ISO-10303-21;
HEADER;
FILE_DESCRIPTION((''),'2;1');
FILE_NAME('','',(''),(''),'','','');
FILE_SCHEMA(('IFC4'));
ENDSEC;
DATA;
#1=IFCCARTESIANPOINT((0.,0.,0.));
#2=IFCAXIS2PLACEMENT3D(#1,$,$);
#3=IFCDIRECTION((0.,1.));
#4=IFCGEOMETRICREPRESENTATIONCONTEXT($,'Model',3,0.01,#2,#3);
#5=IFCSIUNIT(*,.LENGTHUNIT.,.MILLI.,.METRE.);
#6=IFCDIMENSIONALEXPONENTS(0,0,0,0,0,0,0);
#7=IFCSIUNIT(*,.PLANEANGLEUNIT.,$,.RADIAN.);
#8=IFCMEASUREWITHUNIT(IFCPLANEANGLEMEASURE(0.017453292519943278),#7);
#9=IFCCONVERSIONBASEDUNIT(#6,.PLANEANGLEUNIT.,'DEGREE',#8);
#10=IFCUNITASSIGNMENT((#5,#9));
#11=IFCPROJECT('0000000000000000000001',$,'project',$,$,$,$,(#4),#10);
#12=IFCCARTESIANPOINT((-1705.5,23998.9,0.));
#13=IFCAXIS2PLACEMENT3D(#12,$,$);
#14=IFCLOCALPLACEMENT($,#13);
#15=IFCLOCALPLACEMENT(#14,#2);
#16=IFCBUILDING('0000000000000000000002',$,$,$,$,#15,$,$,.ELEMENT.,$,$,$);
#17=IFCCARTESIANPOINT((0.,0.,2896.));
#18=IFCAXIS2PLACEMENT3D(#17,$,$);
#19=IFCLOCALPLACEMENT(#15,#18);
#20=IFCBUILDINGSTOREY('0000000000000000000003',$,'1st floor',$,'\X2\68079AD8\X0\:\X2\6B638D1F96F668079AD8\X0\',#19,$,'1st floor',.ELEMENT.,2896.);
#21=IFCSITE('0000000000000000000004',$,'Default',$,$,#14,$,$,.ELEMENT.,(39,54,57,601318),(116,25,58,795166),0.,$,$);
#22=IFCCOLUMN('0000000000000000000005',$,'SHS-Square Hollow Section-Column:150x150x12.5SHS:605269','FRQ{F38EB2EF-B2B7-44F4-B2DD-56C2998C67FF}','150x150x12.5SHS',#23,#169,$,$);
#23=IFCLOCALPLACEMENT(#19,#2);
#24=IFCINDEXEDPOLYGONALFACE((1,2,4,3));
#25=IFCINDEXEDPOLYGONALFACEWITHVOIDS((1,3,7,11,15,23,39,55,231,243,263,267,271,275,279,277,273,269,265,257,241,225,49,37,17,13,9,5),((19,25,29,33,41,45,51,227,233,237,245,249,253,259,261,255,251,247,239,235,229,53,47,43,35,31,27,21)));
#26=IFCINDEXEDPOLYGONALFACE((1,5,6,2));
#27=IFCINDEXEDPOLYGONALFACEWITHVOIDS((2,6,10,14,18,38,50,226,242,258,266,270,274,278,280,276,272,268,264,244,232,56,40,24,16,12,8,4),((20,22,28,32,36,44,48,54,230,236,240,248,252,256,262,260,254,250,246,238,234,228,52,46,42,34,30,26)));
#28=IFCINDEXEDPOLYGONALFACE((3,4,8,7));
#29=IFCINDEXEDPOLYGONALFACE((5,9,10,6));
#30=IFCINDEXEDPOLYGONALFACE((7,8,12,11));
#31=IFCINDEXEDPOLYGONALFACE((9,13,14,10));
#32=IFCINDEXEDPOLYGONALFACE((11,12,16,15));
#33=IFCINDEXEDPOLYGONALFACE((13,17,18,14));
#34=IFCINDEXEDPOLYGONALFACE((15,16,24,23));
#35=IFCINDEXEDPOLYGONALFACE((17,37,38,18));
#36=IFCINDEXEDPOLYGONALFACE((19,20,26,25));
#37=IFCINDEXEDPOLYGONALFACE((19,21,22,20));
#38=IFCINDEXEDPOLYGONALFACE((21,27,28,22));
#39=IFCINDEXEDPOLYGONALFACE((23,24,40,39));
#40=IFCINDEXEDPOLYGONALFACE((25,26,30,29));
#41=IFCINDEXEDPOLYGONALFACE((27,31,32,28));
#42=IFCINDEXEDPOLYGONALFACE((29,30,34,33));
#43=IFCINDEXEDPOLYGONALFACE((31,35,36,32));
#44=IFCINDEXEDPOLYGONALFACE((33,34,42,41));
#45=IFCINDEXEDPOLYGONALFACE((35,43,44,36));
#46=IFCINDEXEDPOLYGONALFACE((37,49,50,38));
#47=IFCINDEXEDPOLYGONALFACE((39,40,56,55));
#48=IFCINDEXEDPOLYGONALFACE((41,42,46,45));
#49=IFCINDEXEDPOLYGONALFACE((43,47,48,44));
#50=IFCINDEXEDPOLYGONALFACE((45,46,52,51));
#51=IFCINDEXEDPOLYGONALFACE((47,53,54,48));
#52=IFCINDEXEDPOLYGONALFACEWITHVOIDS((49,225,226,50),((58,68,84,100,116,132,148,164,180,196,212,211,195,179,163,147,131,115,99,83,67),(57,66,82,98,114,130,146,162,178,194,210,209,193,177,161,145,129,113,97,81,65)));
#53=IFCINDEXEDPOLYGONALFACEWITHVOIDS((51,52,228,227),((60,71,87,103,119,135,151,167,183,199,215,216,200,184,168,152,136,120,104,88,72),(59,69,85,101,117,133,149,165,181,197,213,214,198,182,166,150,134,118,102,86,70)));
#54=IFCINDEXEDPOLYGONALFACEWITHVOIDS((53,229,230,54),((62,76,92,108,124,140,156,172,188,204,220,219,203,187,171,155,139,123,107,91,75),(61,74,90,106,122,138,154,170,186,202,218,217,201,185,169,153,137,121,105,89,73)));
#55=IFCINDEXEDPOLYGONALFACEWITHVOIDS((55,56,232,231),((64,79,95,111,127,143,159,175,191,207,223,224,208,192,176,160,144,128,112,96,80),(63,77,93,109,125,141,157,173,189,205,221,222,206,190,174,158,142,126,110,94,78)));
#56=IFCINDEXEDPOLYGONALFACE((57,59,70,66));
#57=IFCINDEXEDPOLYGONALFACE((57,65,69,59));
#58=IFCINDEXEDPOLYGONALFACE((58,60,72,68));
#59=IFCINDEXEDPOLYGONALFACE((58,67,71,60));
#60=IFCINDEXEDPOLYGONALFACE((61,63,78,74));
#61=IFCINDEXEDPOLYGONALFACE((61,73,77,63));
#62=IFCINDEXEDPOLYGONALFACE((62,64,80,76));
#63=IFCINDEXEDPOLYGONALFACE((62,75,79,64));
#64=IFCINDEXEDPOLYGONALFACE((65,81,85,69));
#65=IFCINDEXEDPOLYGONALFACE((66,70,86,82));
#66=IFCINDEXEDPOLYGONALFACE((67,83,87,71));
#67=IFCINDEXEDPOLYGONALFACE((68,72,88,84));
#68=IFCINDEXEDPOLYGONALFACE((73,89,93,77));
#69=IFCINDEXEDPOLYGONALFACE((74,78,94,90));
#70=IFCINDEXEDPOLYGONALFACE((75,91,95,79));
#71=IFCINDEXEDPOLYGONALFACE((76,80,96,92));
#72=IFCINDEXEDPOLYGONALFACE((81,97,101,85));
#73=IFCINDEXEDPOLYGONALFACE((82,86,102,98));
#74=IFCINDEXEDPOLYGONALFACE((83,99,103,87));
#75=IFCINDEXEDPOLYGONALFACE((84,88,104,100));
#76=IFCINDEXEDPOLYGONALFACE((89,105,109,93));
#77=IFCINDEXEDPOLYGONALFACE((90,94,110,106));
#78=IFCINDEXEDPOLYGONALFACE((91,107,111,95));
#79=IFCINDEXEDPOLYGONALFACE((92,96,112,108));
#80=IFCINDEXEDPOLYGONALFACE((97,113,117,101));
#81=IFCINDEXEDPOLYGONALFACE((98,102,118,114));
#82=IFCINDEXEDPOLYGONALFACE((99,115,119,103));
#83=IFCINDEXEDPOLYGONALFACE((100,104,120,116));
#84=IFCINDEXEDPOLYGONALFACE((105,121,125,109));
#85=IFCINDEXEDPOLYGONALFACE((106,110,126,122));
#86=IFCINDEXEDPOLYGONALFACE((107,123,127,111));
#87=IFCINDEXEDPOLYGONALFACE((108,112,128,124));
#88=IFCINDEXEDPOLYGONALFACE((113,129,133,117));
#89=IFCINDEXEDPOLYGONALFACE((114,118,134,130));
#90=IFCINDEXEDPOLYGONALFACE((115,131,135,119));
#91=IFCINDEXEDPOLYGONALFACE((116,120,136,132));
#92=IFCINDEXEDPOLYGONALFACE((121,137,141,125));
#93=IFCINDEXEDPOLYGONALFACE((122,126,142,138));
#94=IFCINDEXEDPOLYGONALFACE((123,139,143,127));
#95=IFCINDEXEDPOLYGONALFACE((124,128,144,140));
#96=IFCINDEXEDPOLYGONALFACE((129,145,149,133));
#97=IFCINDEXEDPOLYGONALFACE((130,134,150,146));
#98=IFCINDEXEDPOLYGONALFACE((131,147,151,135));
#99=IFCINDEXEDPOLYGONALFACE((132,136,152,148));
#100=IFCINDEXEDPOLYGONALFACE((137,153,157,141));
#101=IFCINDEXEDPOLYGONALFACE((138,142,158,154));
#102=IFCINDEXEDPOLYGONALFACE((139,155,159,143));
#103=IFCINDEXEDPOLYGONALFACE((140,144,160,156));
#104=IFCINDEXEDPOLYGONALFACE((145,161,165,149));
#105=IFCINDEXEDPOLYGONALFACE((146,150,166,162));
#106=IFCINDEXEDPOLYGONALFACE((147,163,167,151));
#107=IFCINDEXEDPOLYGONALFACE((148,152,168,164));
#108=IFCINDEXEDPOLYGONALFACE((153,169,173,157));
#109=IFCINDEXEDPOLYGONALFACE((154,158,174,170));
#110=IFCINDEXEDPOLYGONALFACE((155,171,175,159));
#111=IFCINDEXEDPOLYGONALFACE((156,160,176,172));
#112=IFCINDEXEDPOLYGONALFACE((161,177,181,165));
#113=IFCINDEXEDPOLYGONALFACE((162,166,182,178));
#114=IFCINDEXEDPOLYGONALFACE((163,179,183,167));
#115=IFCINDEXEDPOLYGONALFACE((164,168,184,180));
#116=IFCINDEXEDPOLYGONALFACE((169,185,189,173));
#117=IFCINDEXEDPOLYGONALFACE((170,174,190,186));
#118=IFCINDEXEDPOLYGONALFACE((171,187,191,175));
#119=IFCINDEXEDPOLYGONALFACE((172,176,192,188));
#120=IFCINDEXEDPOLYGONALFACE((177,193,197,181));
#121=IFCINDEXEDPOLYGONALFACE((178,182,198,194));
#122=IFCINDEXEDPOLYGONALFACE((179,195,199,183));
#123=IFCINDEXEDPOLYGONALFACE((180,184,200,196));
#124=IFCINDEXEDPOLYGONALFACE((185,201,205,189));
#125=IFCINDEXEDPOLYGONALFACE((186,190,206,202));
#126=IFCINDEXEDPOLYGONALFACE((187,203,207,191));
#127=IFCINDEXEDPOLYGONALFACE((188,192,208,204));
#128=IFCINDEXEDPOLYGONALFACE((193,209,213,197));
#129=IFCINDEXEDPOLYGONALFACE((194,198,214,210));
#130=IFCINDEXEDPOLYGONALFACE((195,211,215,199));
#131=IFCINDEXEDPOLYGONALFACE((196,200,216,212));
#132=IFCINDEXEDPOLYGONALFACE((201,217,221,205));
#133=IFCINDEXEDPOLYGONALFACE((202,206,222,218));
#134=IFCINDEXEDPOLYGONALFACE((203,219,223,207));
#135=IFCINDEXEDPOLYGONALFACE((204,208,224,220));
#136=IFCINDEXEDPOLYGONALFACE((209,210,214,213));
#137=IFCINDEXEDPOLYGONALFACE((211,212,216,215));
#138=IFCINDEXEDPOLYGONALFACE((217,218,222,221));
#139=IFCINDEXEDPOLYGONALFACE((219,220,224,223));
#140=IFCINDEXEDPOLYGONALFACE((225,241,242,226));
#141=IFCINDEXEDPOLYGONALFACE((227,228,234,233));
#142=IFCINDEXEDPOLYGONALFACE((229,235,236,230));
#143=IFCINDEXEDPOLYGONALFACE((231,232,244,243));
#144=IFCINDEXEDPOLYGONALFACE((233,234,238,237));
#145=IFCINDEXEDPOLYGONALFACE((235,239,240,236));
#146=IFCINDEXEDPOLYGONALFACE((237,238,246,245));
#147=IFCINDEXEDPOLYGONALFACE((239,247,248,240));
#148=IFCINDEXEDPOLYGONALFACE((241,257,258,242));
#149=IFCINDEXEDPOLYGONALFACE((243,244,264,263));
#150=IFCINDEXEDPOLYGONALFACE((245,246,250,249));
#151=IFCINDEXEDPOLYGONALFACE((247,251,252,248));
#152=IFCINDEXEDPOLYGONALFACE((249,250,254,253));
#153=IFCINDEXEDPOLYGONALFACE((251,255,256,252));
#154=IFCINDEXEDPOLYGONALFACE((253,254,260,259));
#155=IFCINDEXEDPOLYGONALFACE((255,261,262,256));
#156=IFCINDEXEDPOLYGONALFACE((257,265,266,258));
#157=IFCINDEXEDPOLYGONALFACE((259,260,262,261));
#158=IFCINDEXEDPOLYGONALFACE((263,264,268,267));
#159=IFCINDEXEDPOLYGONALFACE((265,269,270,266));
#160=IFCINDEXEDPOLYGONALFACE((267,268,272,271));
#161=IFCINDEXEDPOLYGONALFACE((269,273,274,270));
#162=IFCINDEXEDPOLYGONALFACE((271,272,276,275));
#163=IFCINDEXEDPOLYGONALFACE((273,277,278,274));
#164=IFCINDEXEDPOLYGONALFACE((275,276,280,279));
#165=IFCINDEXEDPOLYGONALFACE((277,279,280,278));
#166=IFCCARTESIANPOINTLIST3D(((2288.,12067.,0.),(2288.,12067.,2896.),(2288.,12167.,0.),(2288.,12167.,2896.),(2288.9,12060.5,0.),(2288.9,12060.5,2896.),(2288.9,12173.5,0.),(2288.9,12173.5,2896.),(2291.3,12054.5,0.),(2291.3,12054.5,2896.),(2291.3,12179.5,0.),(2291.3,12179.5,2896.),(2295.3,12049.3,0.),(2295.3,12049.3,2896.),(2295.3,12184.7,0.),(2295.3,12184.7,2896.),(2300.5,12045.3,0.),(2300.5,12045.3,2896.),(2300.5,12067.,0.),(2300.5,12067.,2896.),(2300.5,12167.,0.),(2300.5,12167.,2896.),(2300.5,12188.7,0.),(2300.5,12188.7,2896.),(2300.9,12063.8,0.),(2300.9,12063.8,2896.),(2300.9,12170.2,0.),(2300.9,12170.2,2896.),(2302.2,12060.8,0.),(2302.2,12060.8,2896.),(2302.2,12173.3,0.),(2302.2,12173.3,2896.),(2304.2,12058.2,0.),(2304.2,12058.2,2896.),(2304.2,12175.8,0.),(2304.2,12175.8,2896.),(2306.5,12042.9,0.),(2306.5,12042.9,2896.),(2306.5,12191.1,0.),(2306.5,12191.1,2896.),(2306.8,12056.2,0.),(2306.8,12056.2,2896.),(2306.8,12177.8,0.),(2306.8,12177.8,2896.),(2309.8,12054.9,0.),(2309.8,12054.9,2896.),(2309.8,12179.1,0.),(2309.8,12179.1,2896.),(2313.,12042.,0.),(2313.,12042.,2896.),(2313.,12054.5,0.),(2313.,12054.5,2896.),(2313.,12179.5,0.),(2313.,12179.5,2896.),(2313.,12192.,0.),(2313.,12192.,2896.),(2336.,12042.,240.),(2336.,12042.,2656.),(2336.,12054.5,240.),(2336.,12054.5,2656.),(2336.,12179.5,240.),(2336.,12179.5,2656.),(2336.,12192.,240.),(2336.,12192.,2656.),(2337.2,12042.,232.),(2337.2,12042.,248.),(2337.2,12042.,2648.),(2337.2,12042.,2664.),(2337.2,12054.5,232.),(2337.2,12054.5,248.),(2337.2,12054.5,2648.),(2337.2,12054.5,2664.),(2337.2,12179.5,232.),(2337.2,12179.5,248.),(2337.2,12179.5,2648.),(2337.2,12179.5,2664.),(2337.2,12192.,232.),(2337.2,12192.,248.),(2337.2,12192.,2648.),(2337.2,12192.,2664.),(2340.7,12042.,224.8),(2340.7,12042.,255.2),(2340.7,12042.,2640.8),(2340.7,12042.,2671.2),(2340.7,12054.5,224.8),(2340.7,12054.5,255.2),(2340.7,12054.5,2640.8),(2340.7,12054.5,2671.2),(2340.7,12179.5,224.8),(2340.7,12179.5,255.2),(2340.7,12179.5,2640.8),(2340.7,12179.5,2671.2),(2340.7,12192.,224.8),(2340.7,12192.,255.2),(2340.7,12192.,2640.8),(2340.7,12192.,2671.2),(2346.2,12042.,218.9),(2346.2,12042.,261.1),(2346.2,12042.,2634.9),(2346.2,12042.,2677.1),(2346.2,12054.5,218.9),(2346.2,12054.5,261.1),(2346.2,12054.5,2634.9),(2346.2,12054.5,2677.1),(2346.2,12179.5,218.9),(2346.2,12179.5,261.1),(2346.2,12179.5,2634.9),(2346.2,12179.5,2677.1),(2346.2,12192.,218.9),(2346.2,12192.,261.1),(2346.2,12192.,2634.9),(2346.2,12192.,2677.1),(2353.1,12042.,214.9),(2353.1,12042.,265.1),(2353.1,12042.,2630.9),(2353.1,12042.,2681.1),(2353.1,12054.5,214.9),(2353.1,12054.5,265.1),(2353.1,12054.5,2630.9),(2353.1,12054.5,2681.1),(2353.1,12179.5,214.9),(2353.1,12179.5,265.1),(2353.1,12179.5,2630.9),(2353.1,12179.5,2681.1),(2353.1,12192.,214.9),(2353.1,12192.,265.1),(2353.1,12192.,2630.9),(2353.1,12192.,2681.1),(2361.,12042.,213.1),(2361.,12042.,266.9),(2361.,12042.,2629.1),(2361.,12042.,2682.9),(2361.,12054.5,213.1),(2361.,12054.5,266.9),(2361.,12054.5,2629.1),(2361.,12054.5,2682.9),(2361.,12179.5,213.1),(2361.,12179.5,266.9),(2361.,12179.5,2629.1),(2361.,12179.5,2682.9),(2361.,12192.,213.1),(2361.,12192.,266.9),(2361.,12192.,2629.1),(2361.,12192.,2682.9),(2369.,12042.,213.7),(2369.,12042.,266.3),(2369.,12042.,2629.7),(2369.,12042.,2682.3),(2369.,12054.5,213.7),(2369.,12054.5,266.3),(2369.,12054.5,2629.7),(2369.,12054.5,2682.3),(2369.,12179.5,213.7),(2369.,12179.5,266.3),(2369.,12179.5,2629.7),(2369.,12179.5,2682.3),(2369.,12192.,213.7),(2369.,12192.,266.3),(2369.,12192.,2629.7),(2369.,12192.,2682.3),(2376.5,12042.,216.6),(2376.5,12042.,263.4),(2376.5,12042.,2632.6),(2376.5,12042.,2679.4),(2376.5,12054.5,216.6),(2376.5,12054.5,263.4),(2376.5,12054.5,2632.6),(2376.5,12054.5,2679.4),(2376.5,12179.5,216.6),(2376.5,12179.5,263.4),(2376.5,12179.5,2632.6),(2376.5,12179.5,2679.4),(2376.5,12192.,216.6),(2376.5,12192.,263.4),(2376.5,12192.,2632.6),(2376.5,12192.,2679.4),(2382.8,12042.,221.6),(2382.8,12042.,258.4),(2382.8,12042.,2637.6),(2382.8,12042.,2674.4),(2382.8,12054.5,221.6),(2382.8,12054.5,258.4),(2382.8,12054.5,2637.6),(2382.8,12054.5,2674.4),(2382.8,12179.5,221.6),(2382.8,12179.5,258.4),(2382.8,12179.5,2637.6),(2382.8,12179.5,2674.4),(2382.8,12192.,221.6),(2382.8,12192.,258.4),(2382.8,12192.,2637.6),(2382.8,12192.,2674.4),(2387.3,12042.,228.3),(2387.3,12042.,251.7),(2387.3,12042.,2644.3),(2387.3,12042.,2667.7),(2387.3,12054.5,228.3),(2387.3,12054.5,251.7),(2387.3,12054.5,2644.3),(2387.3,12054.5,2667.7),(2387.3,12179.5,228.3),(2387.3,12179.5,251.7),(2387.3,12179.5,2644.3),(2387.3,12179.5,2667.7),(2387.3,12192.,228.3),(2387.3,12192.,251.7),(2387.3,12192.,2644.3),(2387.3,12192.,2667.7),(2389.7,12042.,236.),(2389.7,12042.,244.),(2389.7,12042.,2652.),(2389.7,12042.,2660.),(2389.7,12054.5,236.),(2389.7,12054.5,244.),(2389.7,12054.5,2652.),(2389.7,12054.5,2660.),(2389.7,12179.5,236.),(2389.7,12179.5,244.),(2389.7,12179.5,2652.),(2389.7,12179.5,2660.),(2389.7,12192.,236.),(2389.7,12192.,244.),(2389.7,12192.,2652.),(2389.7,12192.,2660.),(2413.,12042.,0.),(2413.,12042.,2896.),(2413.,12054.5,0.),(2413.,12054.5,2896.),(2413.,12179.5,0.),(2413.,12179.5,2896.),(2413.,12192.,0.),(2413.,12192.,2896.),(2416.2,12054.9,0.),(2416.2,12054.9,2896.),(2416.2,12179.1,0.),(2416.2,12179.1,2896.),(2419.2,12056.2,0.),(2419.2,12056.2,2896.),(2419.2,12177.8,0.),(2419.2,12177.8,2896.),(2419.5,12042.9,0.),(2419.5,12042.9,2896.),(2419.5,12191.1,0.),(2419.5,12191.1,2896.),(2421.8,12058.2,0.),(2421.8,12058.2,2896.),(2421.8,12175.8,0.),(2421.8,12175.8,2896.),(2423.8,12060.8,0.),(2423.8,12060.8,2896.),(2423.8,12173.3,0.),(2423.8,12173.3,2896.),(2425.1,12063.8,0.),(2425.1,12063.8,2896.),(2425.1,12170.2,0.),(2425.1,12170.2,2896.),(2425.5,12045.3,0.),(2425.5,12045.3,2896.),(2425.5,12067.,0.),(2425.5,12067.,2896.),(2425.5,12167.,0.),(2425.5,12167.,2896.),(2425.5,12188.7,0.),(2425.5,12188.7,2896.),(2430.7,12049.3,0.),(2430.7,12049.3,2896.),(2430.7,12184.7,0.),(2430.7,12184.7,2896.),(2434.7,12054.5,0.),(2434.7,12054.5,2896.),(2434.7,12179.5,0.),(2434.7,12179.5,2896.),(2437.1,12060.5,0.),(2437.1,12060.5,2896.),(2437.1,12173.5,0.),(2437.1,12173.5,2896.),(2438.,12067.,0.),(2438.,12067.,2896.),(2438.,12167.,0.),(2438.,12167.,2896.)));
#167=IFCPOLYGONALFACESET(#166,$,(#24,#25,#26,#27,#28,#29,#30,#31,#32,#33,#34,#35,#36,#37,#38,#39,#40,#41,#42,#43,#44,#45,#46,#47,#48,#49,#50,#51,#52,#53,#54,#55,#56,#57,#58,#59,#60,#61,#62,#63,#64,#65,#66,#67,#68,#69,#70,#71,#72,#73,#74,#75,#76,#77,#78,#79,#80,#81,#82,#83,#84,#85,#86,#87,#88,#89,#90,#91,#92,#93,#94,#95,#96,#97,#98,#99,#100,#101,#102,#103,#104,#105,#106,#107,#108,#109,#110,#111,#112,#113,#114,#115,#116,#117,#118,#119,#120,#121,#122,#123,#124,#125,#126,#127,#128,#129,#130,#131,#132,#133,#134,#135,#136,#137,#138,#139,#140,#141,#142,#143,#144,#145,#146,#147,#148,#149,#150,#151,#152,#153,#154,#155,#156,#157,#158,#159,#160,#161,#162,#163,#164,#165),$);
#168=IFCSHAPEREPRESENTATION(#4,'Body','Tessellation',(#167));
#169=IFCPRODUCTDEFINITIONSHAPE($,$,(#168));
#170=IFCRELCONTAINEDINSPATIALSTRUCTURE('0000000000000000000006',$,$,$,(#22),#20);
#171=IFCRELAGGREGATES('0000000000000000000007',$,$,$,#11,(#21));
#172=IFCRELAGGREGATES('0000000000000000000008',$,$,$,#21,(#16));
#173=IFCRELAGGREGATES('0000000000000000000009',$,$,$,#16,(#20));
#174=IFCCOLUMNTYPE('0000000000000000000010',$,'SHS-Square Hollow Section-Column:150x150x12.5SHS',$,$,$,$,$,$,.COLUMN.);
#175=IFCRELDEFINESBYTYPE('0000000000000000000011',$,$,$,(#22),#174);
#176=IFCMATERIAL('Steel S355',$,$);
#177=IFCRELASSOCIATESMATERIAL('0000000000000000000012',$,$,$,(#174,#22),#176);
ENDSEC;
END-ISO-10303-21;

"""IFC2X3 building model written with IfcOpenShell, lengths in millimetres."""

from ifc_helpers import new_model, entity, si_unit, converted_unit, direction, frame, frame_2d, origin, origin_2d, place, context, project, spatial, circle_curve, hollow_rectangle, outline, extrude, material, type_object, element, save


model = new_model("IFC2X3")

# Units and contexts
model_context = context("Model", 3, precision=0.01, world=origin(), true_north=direction((0.0, 1.0)))
ifc_project = project(units=[si_unit("LENGTHUNIT", "METRE", prefix="MILLI"), converted_unit("PLANEANGLEUNIT", "DEGREE", entity("IfcPlaneAngleMeasure", 0.017453292519943278), si_unit("PLANEANGLEUNIT", "RADIAN"), dimensions=[0, 0, 0, 0, 0, 0, 0])], contexts=[model_context])

# Site, building, storey
site_placement = place(None, frame((-1705.5, 23998.9, 0.0)))
site = spatial("IfcSite", under=ifc_project, at=site_placement, Name="Default", CompositionType="ELEMENT", RefLatitude=(39, 54, 57, 601318), RefLongitude=(116, 25, 58, 795166), RefElevation=0.0)
building_placement = place(site_placement, origin())
building = spatial("IfcBuilding", under=site, at=building_placement, CompositionType="ELEMENT")
storey_placement = place(building_placement, frame((0.0, 0.0, 2896.0)))
storey = spatial("IfcBuildingStorey", under=building, at=storey_placement, Name="1st floor", ObjectType="标高:正负零标高", LongName="1st floor", CompositionType="ELEMENT", Elevation=2896.0)

# Column, openings
ifc_material_1 = material(Name="Steel S355")
column_type_1 = type_object("IfcColumnType", Name="SHS-Square Hollow Section-Column:150x150x12.5SHS", PredefinedType="COLUMN", material=ifc_material_1)
column_1_placement = place(storey_placement, frame((2363.0, 12117.0, 2896.0), z_axis=(0.0, 0.0, 1.0), x_axis=(0.0, -1.0, 0.0)))
column_1 = element("IfcColumn", 1, at=column_1_placement, inside=storey, type_object=column_type_1, material=ifc_material_1, Name="SHS-Square Hollow Section-Column:150x150x12.5SHS:605269", Description="FRQ{F38EB2EF-B2B7-44F4-B2DD-56C2998C67FF}", ObjectType="150x150x12.5SHS", context=model_context, shape_type="SweptSolid", body=[
    extrude(hollow_rectangle(XDim=150.0, YDim=150.0, WallThickness=12.5, InnerFilletRadius=12.5, OuterFilletRadius=25.0, at=origin_2d()), origin(), (0.0, 0.0, -1.0), 2896.0),
])
opening_1_placement = place(column_1_placement, frame((175.1, 0.0, 0.0), z_axis=(-1.0, 0.0, 0.0), x_axis=(0.0, -1.0, 0.0)))
element("IfcOpeningElement", 2, at=opening_1_placement, cuts=column_1, ObjectType="Opening", context=model_context, shape_type="SweptSolid", body=[
    extrude(outline(circle_curve(frame_2d((0.0, -240.0), x_axis=(1.0, 0.0)), 27.0)), origin(), (0.0, 0.0, 1.0), 350.2),
])
opening_2_placement = place(column_1_placement, frame((175.1, 0.0, -2896.0), z_axis=(-1.0, 0.0, 0.0), x_axis=(0.0, -1.0, 0.0)))
element("IfcOpeningElement", 3, at=opening_2_placement, cuts=column_1, ObjectType="Opening", context=model_context, shape_type="SweptSolid", body=[
    extrude(outline(circle_curve(frame_2d((0.0, 240.0), x_axis=(1.0, 0.0)), 27.0)), origin(), (0.0, 0.0, 1.0), 350.2),
])

save(model, "model.ifc")
